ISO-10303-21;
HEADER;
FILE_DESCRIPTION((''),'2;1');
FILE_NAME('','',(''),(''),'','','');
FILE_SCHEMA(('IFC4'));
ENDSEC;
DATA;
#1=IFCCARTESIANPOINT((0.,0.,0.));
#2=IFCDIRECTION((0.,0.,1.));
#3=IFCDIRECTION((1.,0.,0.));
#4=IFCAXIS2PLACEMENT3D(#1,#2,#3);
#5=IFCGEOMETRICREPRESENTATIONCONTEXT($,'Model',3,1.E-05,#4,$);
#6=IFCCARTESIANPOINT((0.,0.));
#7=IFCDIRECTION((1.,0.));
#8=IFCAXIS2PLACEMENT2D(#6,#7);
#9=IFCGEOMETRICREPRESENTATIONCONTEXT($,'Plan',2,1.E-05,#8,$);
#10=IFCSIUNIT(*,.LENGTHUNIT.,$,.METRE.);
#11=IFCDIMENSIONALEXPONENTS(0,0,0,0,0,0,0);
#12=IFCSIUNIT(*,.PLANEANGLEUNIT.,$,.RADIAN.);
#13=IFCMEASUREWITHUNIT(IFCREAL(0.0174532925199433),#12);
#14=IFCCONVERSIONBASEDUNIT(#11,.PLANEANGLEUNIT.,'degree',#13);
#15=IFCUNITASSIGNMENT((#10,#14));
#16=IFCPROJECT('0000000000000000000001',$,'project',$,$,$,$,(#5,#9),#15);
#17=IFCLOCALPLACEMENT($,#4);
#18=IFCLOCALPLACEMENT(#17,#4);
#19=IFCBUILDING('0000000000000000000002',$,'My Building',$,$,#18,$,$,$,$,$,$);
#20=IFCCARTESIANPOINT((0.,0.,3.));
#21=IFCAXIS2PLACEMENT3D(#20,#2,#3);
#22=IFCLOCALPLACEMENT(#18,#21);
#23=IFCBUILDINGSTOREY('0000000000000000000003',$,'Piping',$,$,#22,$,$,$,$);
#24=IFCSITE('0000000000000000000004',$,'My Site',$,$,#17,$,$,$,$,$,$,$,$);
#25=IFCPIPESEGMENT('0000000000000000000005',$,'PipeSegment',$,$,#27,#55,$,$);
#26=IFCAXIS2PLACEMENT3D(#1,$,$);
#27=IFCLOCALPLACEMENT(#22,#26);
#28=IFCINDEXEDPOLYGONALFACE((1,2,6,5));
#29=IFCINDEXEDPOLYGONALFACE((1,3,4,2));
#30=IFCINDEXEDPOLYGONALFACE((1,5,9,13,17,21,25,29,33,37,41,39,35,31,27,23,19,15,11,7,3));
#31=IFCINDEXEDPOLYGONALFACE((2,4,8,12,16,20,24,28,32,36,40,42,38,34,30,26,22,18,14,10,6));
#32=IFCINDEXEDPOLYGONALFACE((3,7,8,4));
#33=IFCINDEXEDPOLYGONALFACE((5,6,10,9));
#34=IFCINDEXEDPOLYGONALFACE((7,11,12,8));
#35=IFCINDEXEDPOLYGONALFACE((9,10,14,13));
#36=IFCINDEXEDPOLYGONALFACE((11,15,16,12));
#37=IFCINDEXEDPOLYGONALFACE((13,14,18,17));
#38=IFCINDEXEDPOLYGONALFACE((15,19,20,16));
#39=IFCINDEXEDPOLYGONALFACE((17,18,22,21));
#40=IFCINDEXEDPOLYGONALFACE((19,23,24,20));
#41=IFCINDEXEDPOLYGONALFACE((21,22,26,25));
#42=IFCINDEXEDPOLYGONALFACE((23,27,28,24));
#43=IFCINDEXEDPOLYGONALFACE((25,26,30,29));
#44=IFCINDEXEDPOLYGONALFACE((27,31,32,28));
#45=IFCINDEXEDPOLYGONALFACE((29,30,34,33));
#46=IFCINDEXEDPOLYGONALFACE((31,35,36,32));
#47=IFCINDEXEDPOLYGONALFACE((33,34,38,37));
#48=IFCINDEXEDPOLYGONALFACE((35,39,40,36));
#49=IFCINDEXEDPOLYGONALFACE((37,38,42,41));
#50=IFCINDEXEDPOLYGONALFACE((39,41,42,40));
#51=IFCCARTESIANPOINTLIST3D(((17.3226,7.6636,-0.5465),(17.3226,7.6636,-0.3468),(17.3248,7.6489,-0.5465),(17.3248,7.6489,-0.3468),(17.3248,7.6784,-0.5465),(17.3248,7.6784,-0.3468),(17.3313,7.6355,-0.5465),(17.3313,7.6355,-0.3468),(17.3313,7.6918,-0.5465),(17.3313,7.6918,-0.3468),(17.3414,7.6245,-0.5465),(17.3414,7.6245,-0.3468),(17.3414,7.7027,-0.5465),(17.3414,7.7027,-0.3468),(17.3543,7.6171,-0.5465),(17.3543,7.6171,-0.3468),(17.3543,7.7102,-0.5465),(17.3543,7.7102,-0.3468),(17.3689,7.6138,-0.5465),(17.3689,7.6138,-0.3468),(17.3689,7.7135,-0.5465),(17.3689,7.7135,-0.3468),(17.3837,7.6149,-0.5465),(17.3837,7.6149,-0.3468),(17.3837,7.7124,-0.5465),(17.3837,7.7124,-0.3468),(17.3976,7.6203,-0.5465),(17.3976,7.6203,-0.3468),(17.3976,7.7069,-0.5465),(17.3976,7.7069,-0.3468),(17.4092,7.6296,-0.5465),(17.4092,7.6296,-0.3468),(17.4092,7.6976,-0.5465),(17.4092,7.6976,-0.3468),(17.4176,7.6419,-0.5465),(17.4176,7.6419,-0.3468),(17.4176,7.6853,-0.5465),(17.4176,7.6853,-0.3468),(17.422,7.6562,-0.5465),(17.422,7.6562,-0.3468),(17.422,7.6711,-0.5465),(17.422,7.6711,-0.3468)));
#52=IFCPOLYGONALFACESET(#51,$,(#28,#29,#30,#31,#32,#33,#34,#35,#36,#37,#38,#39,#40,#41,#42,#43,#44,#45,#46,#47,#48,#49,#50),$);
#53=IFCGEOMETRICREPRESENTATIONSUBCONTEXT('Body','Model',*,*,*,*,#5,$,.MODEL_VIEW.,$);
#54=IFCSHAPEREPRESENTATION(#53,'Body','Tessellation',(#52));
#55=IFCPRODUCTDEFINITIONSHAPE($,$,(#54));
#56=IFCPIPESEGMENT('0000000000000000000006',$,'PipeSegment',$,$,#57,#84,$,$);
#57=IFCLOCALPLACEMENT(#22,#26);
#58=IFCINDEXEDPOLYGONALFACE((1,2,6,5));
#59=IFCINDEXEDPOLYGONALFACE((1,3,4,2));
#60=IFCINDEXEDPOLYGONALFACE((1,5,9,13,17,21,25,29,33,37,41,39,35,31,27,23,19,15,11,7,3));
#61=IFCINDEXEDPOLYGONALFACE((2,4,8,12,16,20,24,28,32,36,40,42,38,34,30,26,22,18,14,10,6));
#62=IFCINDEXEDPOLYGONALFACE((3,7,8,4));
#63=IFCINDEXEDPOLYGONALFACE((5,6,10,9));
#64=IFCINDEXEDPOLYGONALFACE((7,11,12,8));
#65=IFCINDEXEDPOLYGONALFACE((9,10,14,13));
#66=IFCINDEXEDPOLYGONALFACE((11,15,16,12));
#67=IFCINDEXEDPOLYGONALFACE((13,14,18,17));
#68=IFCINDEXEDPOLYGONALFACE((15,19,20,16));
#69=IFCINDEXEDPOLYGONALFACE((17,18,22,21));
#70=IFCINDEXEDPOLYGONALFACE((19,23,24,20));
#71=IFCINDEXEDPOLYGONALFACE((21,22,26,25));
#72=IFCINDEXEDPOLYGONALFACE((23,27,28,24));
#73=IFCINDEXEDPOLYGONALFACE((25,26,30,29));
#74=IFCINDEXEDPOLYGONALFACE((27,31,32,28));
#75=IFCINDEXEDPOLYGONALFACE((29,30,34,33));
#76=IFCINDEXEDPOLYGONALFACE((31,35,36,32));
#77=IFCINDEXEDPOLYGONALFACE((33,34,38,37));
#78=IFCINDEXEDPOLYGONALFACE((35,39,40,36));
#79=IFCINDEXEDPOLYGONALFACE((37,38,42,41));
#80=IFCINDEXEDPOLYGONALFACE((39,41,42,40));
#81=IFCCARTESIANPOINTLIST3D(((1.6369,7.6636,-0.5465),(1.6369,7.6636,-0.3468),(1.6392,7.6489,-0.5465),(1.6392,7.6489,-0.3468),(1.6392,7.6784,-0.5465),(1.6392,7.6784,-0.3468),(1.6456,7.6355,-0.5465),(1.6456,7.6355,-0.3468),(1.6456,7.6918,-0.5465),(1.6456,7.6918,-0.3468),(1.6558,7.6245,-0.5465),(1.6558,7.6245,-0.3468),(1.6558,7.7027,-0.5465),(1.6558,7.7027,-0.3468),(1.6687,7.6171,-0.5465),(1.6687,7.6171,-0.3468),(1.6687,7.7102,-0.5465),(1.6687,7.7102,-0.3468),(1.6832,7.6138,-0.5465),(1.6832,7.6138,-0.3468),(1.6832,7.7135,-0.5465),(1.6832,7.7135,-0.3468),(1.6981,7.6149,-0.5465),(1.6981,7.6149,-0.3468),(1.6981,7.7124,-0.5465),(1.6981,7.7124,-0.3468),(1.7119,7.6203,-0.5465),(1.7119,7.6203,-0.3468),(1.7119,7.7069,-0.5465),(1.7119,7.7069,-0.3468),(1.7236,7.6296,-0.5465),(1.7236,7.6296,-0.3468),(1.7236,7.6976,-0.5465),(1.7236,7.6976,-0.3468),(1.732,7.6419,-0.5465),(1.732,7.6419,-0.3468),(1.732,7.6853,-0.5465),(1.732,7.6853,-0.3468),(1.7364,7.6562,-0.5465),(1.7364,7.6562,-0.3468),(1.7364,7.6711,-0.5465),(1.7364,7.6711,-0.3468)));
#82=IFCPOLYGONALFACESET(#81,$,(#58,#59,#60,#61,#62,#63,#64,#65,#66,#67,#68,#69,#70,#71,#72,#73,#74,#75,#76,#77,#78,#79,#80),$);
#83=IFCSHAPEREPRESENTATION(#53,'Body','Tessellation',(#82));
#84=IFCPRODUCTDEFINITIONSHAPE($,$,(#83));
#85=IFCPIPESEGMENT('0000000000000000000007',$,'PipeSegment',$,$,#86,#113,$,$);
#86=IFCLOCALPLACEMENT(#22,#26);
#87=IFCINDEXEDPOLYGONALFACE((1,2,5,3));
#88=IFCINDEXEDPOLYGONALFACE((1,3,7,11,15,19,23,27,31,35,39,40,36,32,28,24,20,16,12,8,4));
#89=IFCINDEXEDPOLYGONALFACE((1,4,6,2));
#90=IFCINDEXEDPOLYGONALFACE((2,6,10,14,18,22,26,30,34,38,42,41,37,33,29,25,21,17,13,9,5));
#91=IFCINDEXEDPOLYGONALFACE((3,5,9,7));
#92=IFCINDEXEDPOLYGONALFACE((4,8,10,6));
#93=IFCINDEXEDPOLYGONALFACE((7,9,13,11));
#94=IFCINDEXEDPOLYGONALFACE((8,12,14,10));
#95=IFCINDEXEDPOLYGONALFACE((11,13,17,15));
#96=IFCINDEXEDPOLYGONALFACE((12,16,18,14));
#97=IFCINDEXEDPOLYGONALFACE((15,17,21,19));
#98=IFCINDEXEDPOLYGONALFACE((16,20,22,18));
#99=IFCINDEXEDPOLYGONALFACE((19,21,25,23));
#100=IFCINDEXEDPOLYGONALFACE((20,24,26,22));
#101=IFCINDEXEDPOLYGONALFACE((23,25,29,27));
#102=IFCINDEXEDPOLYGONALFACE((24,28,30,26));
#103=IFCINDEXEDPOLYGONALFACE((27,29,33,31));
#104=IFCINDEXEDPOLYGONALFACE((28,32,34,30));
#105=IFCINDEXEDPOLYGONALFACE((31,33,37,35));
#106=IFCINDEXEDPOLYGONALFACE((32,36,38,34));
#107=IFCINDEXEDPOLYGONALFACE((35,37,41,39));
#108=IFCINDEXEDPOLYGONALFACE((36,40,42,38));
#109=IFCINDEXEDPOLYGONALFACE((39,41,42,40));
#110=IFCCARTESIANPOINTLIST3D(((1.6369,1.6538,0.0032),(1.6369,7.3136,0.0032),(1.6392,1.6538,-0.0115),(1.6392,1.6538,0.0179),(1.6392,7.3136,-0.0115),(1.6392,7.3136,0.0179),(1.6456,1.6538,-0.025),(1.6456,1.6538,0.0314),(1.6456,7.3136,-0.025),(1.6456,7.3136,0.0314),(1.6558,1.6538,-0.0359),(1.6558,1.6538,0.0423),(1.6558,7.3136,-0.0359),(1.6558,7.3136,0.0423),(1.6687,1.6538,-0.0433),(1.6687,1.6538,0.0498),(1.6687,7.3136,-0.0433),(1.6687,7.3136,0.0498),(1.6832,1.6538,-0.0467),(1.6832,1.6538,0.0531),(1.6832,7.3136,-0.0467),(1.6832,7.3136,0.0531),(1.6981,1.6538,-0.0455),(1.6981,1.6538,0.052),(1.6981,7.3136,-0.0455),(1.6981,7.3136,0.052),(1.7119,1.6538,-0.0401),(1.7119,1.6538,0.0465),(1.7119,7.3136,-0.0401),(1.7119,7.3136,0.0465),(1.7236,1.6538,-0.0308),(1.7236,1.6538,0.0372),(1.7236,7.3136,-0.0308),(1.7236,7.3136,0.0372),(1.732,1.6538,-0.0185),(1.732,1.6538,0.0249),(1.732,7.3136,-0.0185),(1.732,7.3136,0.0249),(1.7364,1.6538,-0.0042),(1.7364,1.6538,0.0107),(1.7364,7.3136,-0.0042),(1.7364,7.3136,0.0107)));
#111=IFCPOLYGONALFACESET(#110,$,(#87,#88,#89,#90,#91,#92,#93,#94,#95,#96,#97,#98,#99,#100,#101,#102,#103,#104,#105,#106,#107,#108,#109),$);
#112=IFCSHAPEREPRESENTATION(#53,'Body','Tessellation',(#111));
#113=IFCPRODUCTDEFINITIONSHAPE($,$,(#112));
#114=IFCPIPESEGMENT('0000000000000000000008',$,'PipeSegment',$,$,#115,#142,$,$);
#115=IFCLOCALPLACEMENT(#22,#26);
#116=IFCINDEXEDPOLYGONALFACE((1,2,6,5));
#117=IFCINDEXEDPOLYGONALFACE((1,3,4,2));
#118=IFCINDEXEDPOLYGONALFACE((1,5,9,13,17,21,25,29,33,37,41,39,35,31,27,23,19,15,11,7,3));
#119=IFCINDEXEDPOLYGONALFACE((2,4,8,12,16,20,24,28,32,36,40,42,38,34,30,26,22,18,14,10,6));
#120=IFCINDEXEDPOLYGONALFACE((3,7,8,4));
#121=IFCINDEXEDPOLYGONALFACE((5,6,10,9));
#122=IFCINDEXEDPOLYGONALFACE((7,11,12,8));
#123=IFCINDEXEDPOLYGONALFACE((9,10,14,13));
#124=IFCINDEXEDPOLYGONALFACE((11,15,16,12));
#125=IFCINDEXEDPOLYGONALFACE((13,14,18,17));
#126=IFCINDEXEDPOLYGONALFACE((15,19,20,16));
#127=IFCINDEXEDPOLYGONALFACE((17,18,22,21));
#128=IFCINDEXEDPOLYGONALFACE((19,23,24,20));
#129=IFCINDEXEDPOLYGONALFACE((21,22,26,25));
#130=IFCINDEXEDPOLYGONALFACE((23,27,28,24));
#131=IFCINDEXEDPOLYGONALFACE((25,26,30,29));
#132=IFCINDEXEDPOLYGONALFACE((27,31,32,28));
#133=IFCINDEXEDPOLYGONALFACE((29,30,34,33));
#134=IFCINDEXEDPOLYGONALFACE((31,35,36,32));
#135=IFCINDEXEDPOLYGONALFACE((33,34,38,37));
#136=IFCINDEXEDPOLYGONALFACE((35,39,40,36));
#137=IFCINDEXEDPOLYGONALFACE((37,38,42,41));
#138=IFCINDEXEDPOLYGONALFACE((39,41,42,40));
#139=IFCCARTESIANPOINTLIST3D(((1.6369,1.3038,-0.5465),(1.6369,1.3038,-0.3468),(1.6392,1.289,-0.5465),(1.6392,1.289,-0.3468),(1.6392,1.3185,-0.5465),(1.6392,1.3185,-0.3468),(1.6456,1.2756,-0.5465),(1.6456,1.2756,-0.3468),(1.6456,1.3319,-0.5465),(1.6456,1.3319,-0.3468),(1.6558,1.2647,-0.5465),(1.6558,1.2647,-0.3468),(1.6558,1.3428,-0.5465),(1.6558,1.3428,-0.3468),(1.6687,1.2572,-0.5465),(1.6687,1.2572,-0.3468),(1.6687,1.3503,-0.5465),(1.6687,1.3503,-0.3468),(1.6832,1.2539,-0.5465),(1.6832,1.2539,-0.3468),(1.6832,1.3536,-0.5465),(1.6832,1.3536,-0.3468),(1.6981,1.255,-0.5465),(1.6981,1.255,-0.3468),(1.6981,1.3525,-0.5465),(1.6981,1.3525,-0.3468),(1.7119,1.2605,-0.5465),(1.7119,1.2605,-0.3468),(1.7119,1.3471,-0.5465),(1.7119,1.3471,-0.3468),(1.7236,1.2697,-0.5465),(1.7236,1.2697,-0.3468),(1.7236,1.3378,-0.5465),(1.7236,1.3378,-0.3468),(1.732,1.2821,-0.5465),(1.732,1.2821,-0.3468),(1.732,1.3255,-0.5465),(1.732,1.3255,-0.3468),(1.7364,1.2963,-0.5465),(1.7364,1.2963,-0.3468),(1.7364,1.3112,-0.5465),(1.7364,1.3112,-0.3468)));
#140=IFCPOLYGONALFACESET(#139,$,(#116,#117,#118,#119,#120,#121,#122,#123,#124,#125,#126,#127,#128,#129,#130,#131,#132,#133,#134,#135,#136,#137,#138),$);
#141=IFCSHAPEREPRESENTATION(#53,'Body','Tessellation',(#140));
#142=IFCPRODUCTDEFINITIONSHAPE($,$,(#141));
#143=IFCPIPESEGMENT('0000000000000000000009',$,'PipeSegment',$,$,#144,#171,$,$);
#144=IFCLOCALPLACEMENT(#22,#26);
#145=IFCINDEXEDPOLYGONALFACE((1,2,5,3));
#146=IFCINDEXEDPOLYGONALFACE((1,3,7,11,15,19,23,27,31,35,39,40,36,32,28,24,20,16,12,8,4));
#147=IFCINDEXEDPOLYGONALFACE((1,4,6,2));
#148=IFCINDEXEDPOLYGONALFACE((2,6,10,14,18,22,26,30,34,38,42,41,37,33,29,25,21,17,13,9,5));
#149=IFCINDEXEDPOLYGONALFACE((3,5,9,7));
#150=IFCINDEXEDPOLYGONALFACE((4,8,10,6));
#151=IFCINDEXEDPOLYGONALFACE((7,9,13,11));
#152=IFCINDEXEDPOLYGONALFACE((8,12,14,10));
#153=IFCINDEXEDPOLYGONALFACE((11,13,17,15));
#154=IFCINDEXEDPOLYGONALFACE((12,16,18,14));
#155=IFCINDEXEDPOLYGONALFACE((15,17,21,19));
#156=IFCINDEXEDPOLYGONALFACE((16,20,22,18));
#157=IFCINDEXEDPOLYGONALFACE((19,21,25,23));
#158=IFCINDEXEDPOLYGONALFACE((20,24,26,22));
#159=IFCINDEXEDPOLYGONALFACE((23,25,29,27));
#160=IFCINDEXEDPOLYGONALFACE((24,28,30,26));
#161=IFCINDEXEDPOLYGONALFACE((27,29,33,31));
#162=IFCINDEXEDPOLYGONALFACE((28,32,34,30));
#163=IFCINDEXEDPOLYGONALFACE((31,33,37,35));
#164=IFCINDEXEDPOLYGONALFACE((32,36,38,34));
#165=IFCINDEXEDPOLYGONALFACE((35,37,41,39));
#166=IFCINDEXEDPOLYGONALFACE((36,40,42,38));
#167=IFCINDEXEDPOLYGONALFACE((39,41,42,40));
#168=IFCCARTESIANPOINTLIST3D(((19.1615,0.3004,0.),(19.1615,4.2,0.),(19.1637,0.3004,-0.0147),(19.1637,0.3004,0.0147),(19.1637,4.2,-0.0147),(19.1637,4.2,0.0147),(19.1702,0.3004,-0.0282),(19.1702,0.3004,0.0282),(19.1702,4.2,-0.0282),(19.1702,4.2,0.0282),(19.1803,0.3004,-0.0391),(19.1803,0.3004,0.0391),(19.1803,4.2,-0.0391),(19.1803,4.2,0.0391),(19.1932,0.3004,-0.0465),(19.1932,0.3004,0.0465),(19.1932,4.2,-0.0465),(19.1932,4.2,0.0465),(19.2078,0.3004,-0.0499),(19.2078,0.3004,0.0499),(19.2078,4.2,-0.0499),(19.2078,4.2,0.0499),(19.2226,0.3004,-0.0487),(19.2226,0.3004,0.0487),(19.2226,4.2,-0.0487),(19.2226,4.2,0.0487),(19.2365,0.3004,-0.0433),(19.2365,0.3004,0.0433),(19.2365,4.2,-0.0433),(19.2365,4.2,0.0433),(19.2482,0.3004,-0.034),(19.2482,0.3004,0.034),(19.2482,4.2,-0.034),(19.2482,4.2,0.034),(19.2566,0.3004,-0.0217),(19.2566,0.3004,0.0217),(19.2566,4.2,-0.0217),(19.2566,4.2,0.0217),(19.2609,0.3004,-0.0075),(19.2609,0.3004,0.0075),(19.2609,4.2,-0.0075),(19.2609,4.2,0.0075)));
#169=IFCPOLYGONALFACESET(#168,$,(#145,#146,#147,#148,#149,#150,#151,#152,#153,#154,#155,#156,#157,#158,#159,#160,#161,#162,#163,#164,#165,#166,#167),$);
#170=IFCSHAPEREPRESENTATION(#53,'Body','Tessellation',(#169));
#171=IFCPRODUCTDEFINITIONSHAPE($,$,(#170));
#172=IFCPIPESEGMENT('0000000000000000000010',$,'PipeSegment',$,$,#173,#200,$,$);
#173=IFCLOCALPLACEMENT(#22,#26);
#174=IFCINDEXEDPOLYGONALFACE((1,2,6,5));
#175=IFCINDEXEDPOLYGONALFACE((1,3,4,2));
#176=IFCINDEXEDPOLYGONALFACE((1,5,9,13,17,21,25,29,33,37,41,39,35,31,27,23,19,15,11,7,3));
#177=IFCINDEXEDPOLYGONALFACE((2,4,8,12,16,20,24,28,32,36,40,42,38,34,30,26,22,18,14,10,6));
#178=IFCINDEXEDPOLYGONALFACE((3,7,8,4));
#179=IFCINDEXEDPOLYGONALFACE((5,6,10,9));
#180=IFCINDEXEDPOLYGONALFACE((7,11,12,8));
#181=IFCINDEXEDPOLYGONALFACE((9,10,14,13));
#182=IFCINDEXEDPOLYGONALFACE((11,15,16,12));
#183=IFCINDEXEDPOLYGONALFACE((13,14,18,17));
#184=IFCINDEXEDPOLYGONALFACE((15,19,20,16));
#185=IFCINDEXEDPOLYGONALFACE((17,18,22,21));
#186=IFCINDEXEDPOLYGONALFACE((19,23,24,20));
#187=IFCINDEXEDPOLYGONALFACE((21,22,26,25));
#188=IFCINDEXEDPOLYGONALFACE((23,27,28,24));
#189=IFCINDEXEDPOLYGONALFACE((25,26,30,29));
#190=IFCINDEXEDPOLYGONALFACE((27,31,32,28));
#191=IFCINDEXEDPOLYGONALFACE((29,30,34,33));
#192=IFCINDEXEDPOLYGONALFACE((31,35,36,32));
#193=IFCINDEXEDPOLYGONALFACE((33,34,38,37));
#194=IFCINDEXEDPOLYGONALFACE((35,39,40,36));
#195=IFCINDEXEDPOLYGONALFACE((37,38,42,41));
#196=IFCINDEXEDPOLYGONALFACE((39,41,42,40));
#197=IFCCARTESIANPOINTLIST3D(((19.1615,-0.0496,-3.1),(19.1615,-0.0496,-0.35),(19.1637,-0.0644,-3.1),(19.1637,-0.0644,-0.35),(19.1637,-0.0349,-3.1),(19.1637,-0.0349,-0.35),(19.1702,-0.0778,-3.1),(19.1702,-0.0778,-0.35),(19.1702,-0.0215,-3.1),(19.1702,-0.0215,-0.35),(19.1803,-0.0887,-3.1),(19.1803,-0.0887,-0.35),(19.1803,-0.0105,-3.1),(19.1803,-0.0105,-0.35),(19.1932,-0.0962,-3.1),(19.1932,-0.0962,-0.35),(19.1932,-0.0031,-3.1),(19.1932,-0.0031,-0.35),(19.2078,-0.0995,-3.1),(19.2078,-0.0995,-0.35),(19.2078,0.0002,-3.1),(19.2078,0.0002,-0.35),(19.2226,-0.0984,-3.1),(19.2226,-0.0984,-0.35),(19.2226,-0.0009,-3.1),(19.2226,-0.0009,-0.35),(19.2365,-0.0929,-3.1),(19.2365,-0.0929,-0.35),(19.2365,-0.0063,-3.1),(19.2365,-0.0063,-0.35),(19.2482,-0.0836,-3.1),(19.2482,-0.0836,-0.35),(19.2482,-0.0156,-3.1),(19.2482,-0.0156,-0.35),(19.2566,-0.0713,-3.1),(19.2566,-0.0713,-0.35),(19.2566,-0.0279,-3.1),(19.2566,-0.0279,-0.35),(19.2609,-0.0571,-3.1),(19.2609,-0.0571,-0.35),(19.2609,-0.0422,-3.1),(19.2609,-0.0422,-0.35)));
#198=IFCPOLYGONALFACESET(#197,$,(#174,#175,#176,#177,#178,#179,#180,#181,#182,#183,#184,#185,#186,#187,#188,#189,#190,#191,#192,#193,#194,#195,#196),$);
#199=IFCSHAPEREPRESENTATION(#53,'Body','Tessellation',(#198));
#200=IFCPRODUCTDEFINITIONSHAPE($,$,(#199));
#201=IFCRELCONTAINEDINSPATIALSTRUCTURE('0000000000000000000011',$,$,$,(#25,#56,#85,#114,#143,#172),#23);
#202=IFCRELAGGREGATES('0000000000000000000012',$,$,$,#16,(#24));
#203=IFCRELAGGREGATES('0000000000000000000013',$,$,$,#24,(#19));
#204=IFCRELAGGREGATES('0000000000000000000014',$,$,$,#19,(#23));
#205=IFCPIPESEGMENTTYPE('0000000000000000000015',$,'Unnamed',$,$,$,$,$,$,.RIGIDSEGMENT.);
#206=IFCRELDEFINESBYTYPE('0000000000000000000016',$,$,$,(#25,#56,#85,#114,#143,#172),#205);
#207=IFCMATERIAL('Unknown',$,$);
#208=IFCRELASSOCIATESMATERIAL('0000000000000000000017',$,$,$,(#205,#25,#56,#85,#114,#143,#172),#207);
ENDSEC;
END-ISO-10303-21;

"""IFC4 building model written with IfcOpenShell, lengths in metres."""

from ifc_helpers import new_model, entity, si_unit, converted_unit, frame, origin_with_axes, origin_2d_with_axis, place, context, subcontext, project, spatial, circle, extrude, material, material_profile, profile_set, profile_usage, type_object, element, save


model = new_model("IFC4")

# Units and contexts
model_context = context("Model", 3, precision=1e-05, world=origin_with_axes())
plan_context = context("Plan", 2, precision=1e-05, world=origin_2d_with_axis())
body_context = subcontext(model_context, "Body", "Model", "MODEL_VIEW")
ifc_project = project(units=[si_unit("LENGTHUNIT", "METRE"), converted_unit("PLANEANGLEUNIT", "degree", entity("IfcReal", 0.0174532925199433), si_unit("PLANEANGLEUNIT", "RADIAN"), dimensions=[0, 0, 0, 0, 0, 0, 0])], contexts=[model_context, plan_context])

# Site, building, storey
site_placement = place(None, origin_with_axes())
site = spatial("IfcSite", under=ifc_project, at=site_placement, Name="My Site")
building_placement = place(site_placement, origin_with_axes())
building = spatial("IfcBuilding", under=site, at=building_placement, Name="My Building")
storey_placement = place(building_placement, frame((0.0, 0.0, 3.0), z_axis=(0.0, 0.0, 1.0), x_axis=(1.0, 0.0, 0.0)))
storey = spatial("IfcBuildingStorey", under=building, at=storey_placement, Name="Piping")

# Pipe segments
ifc_material = material(Name="Unknown")
ifc_material_profile = material_profile(ifc_material, circle(Radius=0.05))
ifc_profile_set = profile_set([ifc_material_profile])
pipe_segment_type = type_object("IfcPipeSegmentType", Name="Unnamed", PredefinedType="RIGIDSEGMENT", material=ifc_profile_set)
ifc_profile_usage_1 = profile_usage(ifc_profile_set, cardinal=5)
pipe_segment_1_placement = place(storey_placement, frame((17.3726, 7.6636, -0.3468), z_axis=(0.0, 0.0, -1.0), x_axis=(-1.0, 0.0, 0.0)))
element("IfcPipeSegment", 1, at=pipe_segment_1_placement, inside=storey, type_object=pipe_segment_type, material=ifc_profile_usage_1, Name="PipeSegment", context=body_context, shape_type="SweptSolid", body=[
    extrude(circle(Radius=0.05), origin_with_axes(), (0.0, 0.0, 1.0), 0.1997),
])
ifc_profile_usage_2 = profile_usage(ifc_profile_set, cardinal=5)
pipe_segment_2_placement = place(storey_placement, frame((1.6869, 7.6636, -0.3468), z_axis=(0.0, 0.0, -1.0), x_axis=(-1.0, 0.0, 0.0)))
element("IfcPipeSegment", 2, at=pipe_segment_2_placement, inside=storey, type_object=pipe_segment_type, material=ifc_profile_usage_2, Name="PipeSegment", context=body_context, shape_type="SweptSolid", body=[
    extrude(circle(Radius=0.05), origin_with_axes(), (0.0, 0.0, 1.0), 0.1997),
])
ifc_profile_usage_3 = profile_usage(ifc_profile_set, cardinal=5)
pipe_segment_3_placement = place(storey_placement, frame((1.6869, 1.6538, 0.0032), z_axis=(0.0, 1.0, 0.0), x_axis=(-1.0, 0.0, 0.0)))
element("IfcPipeSegment", 3, at=pipe_segment_3_placement, inside=storey, type_object=pipe_segment_type, material=ifc_profile_usage_3, Name="PipeSegment", context=body_context, shape_type="SweptSolid", body=[
    extrude(circle(Radius=0.05), origin_with_axes(), (0.0, 0.0, 1.0), 5.6599),
])
ifc_profile_usage_4 = profile_usage(ifc_profile_set, cardinal=5)
pipe_segment_4_placement = place(storey_placement, frame((1.6869, 1.3038, -0.3468), z_axis=(0.0, 0.0, -1.0), x_axis=(-1.0, 0.0, 0.0)))
element("IfcPipeSegment", 4, at=pipe_segment_4_placement, inside=storey, type_object=pipe_segment_type, material=ifc_profile_usage_4, Name="PipeSegment", context=body_context, shape_type="SweptSolid", body=[
    extrude(circle(Radius=0.05), origin_with_axes(), (0.0, 0.0, 1.0), 0.1997),
])
ifc_profile_usage_5 = profile_usage(ifc_profile_set, cardinal=5)
pipe_segment_5_placement = place(storey_placement, frame((19.2115, 0.3004, 0.0), z_axis=(0.0, 1.0, 0.0), x_axis=(-1.0, 0.0, 0.0)))
element("IfcPipeSegment", 5, at=pipe_segment_5_placement, inside=storey, type_object=pipe_segment_type, material=ifc_profile_usage_5, Name="PipeSegment", context=body_context, shape_type="SweptSolid", body=[
    extrude(circle(Radius=0.05), origin_with_axes(), (0.0, 0.0, 1.0), 3.8996),
])
ifc_profile_usage_6 = profile_usage(ifc_profile_set, cardinal=5)
pipe_segment_6_placement = place(storey_placement, frame((19.2115, -0.0496, -0.35), z_axis=(0.0, 0.0, -1.0), x_axis=(-1.0, 0.0, 0.0)))
element("IfcPipeSegment", 6, at=pipe_segment_6_placement, inside=storey, type_object=pipe_segment_type, material=ifc_profile_usage_6, Name="PipeSegment", context=body_context, shape_type="SweptSolid", body=[
    extrude(circle(Radius=0.05), origin_with_axes(), (0.0, 0.0, 1.0), 2.75),
])

save(model, "model.ifc")
